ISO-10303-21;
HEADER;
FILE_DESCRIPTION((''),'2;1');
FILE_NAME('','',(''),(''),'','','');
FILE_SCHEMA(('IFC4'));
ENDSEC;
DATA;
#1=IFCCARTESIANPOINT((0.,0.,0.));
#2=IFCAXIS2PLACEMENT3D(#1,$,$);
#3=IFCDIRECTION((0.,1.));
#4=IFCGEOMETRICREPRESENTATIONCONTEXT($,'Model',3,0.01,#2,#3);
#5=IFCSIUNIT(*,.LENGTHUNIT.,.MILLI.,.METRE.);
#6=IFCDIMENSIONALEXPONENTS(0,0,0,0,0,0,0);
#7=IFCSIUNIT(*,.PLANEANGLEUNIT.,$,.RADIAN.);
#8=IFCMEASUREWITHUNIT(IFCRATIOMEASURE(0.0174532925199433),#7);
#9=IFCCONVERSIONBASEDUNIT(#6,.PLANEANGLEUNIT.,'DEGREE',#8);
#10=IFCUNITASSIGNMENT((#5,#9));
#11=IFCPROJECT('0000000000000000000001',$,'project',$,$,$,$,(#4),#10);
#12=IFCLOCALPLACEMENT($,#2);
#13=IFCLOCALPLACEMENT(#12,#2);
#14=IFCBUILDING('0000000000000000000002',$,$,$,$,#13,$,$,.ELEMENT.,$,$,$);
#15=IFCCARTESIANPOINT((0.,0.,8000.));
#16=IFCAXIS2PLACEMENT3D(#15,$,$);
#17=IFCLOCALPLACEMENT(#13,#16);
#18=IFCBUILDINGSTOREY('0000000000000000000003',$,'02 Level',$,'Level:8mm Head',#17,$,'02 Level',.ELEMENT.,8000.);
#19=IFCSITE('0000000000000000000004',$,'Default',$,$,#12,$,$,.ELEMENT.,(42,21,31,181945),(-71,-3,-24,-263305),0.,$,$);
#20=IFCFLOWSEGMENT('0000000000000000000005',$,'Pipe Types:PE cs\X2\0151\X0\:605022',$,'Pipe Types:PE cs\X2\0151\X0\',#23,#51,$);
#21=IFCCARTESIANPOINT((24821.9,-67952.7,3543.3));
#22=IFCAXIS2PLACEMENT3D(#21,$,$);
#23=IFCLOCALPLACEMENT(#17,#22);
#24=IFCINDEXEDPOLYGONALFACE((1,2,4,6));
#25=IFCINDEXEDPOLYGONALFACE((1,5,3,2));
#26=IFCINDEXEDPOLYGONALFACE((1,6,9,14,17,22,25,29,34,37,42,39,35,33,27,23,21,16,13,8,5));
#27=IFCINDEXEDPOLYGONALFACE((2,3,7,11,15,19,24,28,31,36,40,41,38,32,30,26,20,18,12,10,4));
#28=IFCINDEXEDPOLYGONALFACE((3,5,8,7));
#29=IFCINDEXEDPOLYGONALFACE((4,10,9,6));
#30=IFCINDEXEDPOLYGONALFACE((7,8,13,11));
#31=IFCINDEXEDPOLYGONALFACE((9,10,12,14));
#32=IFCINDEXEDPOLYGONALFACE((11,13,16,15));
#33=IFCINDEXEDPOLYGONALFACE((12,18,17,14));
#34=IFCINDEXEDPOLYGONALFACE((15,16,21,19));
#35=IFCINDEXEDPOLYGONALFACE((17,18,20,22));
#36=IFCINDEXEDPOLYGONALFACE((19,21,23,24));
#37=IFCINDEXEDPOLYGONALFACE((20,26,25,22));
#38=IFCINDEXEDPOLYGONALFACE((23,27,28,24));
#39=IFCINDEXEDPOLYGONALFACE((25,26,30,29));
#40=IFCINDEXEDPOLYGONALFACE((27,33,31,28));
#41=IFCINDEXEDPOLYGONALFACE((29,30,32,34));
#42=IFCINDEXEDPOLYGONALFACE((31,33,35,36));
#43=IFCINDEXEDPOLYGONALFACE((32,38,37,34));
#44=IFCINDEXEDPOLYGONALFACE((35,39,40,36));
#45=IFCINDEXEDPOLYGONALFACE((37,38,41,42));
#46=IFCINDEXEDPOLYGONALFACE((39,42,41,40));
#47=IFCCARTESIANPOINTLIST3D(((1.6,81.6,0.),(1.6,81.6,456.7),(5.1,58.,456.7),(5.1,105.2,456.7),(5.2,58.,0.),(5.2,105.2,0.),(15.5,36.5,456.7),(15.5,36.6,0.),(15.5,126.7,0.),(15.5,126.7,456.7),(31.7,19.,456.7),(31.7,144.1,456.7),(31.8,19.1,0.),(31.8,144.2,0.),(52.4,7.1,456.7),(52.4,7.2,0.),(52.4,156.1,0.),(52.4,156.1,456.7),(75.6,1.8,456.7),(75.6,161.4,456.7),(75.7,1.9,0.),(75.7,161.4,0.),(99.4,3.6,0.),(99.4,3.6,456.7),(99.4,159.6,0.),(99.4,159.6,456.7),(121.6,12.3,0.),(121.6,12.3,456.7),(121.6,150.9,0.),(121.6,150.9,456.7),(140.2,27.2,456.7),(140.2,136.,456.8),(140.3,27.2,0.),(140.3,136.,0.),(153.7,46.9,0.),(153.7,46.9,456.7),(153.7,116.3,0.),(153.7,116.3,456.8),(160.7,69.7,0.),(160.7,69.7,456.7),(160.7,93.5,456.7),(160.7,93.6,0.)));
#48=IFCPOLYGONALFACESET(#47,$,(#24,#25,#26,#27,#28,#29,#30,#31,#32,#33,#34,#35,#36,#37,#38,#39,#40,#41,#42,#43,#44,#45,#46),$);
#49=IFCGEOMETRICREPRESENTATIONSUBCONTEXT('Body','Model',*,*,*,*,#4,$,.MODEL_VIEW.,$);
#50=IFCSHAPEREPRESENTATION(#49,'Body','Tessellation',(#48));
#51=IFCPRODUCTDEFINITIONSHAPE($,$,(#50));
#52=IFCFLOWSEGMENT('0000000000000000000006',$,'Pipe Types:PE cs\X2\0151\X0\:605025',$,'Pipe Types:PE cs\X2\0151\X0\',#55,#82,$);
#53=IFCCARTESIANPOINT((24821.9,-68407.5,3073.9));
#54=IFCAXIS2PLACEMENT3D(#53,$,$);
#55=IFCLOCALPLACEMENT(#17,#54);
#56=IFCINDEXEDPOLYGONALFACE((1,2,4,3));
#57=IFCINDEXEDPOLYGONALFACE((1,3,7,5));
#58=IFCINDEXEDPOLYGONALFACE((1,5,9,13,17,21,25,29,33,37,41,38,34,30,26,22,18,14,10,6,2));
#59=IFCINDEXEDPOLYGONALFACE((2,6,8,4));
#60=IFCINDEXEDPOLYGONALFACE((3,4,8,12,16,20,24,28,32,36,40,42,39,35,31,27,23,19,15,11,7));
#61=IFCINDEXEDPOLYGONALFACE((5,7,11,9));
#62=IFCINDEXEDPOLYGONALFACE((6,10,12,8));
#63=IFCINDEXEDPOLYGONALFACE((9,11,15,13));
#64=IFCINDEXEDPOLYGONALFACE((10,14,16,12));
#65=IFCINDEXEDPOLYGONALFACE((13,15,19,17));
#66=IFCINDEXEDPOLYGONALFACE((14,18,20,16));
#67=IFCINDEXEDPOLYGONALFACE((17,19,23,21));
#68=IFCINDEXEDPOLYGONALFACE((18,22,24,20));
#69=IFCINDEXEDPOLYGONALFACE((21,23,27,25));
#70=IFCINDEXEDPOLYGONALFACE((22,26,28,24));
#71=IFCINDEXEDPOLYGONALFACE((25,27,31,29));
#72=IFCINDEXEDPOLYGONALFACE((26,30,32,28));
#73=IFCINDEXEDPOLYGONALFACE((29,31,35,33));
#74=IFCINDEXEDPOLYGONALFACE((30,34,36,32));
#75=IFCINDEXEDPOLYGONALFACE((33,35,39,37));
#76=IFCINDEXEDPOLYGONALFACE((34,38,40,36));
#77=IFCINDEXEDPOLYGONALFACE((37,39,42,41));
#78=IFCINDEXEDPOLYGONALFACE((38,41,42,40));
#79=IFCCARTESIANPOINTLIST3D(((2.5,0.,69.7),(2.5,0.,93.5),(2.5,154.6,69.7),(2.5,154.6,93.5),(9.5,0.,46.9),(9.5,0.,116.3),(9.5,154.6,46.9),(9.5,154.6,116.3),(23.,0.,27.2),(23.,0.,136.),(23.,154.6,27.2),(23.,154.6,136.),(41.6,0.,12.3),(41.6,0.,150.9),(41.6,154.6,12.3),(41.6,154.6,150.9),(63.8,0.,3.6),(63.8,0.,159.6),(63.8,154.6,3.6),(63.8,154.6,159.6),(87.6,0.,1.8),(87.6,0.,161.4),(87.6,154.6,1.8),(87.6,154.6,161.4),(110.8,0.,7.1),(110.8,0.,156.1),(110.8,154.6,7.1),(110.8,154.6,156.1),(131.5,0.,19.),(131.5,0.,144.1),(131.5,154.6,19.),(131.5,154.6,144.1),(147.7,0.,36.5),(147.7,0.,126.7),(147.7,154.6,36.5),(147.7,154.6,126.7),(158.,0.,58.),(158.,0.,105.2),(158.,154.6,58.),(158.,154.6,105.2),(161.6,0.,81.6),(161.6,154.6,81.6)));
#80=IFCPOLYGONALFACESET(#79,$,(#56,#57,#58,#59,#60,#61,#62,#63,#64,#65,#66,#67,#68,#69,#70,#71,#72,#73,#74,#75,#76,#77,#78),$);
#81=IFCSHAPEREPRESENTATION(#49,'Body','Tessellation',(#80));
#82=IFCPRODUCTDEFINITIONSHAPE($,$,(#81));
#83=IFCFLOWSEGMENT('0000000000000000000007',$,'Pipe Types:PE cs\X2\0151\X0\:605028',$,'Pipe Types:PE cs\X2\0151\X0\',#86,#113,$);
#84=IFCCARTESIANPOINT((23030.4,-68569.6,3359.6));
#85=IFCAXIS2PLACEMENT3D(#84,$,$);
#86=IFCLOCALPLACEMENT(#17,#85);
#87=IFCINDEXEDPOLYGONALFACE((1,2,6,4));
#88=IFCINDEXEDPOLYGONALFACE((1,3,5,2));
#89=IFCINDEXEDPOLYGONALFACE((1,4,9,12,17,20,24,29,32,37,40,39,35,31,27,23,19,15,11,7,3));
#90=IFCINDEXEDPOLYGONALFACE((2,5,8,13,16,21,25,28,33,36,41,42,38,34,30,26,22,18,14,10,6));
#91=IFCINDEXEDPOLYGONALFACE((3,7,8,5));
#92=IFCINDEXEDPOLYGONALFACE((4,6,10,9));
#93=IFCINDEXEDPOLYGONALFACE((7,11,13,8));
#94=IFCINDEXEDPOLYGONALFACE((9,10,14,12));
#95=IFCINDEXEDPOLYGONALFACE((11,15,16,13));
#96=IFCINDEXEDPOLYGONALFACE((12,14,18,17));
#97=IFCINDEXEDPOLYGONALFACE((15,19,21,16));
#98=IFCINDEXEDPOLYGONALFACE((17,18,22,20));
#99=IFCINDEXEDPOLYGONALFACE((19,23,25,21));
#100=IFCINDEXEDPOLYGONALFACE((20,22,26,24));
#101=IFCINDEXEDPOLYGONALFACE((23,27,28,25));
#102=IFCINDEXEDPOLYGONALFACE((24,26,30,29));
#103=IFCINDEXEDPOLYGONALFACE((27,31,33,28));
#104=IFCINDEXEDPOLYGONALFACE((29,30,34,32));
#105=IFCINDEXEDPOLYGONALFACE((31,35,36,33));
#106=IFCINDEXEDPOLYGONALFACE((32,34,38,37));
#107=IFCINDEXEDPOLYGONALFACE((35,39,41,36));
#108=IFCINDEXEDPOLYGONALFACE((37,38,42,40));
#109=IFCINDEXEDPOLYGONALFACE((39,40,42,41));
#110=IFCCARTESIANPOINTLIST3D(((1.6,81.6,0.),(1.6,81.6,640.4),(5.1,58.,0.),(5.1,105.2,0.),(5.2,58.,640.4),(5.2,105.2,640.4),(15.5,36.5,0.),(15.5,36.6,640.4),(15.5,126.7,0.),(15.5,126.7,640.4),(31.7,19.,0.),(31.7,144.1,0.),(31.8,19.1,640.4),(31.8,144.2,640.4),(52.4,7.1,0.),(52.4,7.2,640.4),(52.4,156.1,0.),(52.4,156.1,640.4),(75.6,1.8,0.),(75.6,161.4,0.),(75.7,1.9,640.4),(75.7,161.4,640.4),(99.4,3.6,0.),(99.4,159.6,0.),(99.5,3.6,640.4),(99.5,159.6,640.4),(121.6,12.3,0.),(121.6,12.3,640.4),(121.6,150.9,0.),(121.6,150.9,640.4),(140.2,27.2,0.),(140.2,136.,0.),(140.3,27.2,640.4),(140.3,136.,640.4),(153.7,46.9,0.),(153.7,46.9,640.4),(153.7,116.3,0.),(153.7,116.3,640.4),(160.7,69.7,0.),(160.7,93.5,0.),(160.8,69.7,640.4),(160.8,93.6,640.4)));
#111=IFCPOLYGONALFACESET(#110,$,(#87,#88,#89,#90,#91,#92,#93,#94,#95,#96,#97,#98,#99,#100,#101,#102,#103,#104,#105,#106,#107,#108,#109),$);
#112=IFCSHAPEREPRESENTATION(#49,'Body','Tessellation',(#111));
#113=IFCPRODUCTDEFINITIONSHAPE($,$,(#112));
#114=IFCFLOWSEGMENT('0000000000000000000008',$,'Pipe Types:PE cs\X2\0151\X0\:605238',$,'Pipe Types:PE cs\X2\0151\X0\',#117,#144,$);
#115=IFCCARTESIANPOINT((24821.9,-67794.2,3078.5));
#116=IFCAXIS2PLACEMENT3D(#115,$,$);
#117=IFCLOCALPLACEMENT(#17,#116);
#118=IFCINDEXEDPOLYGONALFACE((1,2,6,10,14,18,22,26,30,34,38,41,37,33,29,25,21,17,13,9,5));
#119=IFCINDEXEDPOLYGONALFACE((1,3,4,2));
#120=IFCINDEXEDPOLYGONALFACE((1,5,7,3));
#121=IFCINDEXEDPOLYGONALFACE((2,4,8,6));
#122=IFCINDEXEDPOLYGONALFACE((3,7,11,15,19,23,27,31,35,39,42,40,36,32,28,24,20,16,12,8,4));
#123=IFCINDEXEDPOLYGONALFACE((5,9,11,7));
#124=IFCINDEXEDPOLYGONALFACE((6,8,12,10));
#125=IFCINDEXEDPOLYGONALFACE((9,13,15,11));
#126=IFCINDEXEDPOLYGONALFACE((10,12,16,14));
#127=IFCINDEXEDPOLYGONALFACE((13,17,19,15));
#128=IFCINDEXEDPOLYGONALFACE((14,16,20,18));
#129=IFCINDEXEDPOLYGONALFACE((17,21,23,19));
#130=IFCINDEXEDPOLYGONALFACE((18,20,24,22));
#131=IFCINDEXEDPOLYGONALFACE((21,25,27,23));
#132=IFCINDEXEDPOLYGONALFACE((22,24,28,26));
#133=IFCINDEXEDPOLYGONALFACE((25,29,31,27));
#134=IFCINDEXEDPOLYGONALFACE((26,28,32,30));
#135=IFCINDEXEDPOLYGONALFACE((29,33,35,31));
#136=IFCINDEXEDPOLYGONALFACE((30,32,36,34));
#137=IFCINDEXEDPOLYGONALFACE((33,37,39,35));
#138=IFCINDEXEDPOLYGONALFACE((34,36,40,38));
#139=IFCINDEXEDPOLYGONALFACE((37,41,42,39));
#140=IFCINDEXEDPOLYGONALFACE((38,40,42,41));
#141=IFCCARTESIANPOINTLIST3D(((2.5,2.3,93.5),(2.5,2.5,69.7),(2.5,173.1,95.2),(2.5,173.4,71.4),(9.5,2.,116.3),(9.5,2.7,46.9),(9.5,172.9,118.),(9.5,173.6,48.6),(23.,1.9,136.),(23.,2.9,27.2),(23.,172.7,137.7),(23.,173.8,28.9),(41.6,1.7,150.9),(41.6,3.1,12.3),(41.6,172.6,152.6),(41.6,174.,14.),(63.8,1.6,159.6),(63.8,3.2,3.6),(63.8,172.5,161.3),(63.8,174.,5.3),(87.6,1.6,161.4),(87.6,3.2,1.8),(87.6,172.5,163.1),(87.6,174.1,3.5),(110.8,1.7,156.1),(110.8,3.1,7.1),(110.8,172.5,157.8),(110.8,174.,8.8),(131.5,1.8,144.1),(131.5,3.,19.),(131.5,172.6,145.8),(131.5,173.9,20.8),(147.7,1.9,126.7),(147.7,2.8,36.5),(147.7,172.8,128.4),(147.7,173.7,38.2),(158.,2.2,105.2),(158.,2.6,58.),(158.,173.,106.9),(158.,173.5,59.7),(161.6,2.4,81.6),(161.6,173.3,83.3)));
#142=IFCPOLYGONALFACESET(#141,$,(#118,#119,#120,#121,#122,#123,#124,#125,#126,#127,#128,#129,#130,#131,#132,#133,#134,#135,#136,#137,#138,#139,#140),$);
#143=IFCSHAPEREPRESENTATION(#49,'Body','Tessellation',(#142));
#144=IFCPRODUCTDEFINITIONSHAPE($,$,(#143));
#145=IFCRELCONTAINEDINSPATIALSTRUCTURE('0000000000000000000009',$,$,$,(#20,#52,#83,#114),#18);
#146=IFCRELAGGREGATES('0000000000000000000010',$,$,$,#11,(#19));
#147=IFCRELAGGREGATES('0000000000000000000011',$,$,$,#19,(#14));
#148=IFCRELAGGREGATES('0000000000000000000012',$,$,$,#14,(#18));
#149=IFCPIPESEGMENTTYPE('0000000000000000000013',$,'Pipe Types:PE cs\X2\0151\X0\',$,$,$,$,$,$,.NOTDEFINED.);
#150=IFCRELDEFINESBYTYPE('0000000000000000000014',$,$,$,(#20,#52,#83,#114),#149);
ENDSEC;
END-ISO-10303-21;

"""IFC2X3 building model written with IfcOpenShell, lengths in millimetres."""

from ifc_helpers import new_model, entity, si_unit, converted_unit, direction, frame, frame_2d, origin, origin_2d_with_axis, place, context, subcontext, project, spatial, circle, extrude, type_object, element, save


model = new_model("IFC2X3")

# Units and contexts
model_context = context("Model", 3, precision=0.01, world=origin(), true_north=direction((0.0, 1.0)))
body_context = subcontext(model_context, "Body", "Model", "MODEL_VIEW")
ifc_project = project(units=[si_unit("LENGTHUNIT", "METRE", prefix="MILLI"), converted_unit("PLANEANGLEUNIT", "DEGREE", entity("IfcRatioMeasure", 0.0174532925199433), si_unit("PLANEANGLEUNIT", "RADIAN"), dimensions=[0, 0, 0, 0, 0, 0, 0])], contexts=[model_context])

# Site, building, storey
site_placement = place(None, origin())
site = spatial("IfcSite", under=ifc_project, at=site_placement, Name="Default", CompositionType="ELEMENT", RefLatitude=(42, 21, 31, 181945), RefLongitude=(-71, -3, -24, -263305), RefElevation=0.0)
building_placement = place(site_placement, origin())
building = spatial("IfcBuilding", under=site, at=building_placement, CompositionType="ELEMENT")
storey_placement = place(building_placement, frame((0.0, 0.0, 8000.0)))
storey = spatial("IfcBuildingStorey", under=building, at=storey_placement, Name="02 Level", ObjectType="Level:8mm Head", LongName="02 Level", CompositionType="ELEMENT", Elevation=8000.0)

# Flow segments
pipe_segment_type = type_object("IfcPipeSegmentType", Name="Pipe Types:PE cső", PredefinedType="NOTDEFINED")
flow_segment_1_placement = place(storey_placement, frame((24821.9, -67952.7, 3543.3)))
element("IfcFlowSegment", 1, at=flow_segment_1_placement, inside=storey, type_object=pipe_segment_type, Name="Pipe Types:PE cső:605022", ObjectType="Pipe Types:PE cső", context=body_context, shape_type="SweptSolid", body=[
    extrude(circle(Radius=80.0, at=frame_2d((0.0, 0.0), x_axis=(1.0, 0.0))), frame((81.6, 81.6, 0.0), z_axis=(-0.000102, -0.00007, 1.0), x_axis=(-1.0, 0.0, -0.000102)), (0.0, 0.0, 1.0), 456.7),
])
flow_segment_2_placement = place(storey_placement, frame((24821.9, -68407.5, 3073.9)))
element("IfcFlowSegment", 2, at=flow_segment_2_placement, inside=storey, type_object=pipe_segment_type, Name="Pipe Types:PE cső:605025", ObjectType="Pipe Types:PE cső", context=body_context, shape_type="SweptSolid", body=[
    extrude(circle(Radius=80.0, at=origin_2d_with_axis()), frame((81.6, 0.0, 81.6), z_axis=(0.0, 1.0, 0.0), x_axis=(1.0, 0.0, 0.0)), (0.0, 0.0, 1.0), 154.6),
])
flow_segment_3_placement = place(storey_placement, frame((23030.4, -68569.6, 3359.6)))
element("IfcFlowSegment", 3, at=flow_segment_3_placement, inside=storey, type_object=pipe_segment_type, Name="Pipe Types:PE cső:605028", ObjectType="Pipe Types:PE cső", context=body_context, shape_type="SweptSolid", body=[
    extrude(circle(Radius=80.0, at=frame_2d((0.0, 0.0), x_axis=(1.0, 0.0))), frame((81.6, 81.6, 0.0), z_axis=(0.000084, 0.000051, 1.0), x_axis=(-1.0, 0.0, 0.000084)), (0.0, 0.0, 1.0), 640.4),
])
flow_segment_4_placement = place(storey_placement, frame((24821.9, -67794.2, 3078.5)))
element("IfcFlowSegment", 4, at=flow_segment_4_placement, inside=storey, type_object=pipe_segment_type, Name="Pipe Types:PE cső:605238", ObjectType="Pipe Types:PE cső", context=body_context, shape_type="SweptSolid", body=[
    extrude(circle(Radius=80.0, at=origin_2d_with_axis()), frame((81.6, 2.4, 81.6), z_axis=(0.0, 0.99995, 0.01), x_axis=(1.0, 0.0, 0.0)), (0.0, 0.0, 1.0), 170.9),
])

save(model, "model.ifc")
